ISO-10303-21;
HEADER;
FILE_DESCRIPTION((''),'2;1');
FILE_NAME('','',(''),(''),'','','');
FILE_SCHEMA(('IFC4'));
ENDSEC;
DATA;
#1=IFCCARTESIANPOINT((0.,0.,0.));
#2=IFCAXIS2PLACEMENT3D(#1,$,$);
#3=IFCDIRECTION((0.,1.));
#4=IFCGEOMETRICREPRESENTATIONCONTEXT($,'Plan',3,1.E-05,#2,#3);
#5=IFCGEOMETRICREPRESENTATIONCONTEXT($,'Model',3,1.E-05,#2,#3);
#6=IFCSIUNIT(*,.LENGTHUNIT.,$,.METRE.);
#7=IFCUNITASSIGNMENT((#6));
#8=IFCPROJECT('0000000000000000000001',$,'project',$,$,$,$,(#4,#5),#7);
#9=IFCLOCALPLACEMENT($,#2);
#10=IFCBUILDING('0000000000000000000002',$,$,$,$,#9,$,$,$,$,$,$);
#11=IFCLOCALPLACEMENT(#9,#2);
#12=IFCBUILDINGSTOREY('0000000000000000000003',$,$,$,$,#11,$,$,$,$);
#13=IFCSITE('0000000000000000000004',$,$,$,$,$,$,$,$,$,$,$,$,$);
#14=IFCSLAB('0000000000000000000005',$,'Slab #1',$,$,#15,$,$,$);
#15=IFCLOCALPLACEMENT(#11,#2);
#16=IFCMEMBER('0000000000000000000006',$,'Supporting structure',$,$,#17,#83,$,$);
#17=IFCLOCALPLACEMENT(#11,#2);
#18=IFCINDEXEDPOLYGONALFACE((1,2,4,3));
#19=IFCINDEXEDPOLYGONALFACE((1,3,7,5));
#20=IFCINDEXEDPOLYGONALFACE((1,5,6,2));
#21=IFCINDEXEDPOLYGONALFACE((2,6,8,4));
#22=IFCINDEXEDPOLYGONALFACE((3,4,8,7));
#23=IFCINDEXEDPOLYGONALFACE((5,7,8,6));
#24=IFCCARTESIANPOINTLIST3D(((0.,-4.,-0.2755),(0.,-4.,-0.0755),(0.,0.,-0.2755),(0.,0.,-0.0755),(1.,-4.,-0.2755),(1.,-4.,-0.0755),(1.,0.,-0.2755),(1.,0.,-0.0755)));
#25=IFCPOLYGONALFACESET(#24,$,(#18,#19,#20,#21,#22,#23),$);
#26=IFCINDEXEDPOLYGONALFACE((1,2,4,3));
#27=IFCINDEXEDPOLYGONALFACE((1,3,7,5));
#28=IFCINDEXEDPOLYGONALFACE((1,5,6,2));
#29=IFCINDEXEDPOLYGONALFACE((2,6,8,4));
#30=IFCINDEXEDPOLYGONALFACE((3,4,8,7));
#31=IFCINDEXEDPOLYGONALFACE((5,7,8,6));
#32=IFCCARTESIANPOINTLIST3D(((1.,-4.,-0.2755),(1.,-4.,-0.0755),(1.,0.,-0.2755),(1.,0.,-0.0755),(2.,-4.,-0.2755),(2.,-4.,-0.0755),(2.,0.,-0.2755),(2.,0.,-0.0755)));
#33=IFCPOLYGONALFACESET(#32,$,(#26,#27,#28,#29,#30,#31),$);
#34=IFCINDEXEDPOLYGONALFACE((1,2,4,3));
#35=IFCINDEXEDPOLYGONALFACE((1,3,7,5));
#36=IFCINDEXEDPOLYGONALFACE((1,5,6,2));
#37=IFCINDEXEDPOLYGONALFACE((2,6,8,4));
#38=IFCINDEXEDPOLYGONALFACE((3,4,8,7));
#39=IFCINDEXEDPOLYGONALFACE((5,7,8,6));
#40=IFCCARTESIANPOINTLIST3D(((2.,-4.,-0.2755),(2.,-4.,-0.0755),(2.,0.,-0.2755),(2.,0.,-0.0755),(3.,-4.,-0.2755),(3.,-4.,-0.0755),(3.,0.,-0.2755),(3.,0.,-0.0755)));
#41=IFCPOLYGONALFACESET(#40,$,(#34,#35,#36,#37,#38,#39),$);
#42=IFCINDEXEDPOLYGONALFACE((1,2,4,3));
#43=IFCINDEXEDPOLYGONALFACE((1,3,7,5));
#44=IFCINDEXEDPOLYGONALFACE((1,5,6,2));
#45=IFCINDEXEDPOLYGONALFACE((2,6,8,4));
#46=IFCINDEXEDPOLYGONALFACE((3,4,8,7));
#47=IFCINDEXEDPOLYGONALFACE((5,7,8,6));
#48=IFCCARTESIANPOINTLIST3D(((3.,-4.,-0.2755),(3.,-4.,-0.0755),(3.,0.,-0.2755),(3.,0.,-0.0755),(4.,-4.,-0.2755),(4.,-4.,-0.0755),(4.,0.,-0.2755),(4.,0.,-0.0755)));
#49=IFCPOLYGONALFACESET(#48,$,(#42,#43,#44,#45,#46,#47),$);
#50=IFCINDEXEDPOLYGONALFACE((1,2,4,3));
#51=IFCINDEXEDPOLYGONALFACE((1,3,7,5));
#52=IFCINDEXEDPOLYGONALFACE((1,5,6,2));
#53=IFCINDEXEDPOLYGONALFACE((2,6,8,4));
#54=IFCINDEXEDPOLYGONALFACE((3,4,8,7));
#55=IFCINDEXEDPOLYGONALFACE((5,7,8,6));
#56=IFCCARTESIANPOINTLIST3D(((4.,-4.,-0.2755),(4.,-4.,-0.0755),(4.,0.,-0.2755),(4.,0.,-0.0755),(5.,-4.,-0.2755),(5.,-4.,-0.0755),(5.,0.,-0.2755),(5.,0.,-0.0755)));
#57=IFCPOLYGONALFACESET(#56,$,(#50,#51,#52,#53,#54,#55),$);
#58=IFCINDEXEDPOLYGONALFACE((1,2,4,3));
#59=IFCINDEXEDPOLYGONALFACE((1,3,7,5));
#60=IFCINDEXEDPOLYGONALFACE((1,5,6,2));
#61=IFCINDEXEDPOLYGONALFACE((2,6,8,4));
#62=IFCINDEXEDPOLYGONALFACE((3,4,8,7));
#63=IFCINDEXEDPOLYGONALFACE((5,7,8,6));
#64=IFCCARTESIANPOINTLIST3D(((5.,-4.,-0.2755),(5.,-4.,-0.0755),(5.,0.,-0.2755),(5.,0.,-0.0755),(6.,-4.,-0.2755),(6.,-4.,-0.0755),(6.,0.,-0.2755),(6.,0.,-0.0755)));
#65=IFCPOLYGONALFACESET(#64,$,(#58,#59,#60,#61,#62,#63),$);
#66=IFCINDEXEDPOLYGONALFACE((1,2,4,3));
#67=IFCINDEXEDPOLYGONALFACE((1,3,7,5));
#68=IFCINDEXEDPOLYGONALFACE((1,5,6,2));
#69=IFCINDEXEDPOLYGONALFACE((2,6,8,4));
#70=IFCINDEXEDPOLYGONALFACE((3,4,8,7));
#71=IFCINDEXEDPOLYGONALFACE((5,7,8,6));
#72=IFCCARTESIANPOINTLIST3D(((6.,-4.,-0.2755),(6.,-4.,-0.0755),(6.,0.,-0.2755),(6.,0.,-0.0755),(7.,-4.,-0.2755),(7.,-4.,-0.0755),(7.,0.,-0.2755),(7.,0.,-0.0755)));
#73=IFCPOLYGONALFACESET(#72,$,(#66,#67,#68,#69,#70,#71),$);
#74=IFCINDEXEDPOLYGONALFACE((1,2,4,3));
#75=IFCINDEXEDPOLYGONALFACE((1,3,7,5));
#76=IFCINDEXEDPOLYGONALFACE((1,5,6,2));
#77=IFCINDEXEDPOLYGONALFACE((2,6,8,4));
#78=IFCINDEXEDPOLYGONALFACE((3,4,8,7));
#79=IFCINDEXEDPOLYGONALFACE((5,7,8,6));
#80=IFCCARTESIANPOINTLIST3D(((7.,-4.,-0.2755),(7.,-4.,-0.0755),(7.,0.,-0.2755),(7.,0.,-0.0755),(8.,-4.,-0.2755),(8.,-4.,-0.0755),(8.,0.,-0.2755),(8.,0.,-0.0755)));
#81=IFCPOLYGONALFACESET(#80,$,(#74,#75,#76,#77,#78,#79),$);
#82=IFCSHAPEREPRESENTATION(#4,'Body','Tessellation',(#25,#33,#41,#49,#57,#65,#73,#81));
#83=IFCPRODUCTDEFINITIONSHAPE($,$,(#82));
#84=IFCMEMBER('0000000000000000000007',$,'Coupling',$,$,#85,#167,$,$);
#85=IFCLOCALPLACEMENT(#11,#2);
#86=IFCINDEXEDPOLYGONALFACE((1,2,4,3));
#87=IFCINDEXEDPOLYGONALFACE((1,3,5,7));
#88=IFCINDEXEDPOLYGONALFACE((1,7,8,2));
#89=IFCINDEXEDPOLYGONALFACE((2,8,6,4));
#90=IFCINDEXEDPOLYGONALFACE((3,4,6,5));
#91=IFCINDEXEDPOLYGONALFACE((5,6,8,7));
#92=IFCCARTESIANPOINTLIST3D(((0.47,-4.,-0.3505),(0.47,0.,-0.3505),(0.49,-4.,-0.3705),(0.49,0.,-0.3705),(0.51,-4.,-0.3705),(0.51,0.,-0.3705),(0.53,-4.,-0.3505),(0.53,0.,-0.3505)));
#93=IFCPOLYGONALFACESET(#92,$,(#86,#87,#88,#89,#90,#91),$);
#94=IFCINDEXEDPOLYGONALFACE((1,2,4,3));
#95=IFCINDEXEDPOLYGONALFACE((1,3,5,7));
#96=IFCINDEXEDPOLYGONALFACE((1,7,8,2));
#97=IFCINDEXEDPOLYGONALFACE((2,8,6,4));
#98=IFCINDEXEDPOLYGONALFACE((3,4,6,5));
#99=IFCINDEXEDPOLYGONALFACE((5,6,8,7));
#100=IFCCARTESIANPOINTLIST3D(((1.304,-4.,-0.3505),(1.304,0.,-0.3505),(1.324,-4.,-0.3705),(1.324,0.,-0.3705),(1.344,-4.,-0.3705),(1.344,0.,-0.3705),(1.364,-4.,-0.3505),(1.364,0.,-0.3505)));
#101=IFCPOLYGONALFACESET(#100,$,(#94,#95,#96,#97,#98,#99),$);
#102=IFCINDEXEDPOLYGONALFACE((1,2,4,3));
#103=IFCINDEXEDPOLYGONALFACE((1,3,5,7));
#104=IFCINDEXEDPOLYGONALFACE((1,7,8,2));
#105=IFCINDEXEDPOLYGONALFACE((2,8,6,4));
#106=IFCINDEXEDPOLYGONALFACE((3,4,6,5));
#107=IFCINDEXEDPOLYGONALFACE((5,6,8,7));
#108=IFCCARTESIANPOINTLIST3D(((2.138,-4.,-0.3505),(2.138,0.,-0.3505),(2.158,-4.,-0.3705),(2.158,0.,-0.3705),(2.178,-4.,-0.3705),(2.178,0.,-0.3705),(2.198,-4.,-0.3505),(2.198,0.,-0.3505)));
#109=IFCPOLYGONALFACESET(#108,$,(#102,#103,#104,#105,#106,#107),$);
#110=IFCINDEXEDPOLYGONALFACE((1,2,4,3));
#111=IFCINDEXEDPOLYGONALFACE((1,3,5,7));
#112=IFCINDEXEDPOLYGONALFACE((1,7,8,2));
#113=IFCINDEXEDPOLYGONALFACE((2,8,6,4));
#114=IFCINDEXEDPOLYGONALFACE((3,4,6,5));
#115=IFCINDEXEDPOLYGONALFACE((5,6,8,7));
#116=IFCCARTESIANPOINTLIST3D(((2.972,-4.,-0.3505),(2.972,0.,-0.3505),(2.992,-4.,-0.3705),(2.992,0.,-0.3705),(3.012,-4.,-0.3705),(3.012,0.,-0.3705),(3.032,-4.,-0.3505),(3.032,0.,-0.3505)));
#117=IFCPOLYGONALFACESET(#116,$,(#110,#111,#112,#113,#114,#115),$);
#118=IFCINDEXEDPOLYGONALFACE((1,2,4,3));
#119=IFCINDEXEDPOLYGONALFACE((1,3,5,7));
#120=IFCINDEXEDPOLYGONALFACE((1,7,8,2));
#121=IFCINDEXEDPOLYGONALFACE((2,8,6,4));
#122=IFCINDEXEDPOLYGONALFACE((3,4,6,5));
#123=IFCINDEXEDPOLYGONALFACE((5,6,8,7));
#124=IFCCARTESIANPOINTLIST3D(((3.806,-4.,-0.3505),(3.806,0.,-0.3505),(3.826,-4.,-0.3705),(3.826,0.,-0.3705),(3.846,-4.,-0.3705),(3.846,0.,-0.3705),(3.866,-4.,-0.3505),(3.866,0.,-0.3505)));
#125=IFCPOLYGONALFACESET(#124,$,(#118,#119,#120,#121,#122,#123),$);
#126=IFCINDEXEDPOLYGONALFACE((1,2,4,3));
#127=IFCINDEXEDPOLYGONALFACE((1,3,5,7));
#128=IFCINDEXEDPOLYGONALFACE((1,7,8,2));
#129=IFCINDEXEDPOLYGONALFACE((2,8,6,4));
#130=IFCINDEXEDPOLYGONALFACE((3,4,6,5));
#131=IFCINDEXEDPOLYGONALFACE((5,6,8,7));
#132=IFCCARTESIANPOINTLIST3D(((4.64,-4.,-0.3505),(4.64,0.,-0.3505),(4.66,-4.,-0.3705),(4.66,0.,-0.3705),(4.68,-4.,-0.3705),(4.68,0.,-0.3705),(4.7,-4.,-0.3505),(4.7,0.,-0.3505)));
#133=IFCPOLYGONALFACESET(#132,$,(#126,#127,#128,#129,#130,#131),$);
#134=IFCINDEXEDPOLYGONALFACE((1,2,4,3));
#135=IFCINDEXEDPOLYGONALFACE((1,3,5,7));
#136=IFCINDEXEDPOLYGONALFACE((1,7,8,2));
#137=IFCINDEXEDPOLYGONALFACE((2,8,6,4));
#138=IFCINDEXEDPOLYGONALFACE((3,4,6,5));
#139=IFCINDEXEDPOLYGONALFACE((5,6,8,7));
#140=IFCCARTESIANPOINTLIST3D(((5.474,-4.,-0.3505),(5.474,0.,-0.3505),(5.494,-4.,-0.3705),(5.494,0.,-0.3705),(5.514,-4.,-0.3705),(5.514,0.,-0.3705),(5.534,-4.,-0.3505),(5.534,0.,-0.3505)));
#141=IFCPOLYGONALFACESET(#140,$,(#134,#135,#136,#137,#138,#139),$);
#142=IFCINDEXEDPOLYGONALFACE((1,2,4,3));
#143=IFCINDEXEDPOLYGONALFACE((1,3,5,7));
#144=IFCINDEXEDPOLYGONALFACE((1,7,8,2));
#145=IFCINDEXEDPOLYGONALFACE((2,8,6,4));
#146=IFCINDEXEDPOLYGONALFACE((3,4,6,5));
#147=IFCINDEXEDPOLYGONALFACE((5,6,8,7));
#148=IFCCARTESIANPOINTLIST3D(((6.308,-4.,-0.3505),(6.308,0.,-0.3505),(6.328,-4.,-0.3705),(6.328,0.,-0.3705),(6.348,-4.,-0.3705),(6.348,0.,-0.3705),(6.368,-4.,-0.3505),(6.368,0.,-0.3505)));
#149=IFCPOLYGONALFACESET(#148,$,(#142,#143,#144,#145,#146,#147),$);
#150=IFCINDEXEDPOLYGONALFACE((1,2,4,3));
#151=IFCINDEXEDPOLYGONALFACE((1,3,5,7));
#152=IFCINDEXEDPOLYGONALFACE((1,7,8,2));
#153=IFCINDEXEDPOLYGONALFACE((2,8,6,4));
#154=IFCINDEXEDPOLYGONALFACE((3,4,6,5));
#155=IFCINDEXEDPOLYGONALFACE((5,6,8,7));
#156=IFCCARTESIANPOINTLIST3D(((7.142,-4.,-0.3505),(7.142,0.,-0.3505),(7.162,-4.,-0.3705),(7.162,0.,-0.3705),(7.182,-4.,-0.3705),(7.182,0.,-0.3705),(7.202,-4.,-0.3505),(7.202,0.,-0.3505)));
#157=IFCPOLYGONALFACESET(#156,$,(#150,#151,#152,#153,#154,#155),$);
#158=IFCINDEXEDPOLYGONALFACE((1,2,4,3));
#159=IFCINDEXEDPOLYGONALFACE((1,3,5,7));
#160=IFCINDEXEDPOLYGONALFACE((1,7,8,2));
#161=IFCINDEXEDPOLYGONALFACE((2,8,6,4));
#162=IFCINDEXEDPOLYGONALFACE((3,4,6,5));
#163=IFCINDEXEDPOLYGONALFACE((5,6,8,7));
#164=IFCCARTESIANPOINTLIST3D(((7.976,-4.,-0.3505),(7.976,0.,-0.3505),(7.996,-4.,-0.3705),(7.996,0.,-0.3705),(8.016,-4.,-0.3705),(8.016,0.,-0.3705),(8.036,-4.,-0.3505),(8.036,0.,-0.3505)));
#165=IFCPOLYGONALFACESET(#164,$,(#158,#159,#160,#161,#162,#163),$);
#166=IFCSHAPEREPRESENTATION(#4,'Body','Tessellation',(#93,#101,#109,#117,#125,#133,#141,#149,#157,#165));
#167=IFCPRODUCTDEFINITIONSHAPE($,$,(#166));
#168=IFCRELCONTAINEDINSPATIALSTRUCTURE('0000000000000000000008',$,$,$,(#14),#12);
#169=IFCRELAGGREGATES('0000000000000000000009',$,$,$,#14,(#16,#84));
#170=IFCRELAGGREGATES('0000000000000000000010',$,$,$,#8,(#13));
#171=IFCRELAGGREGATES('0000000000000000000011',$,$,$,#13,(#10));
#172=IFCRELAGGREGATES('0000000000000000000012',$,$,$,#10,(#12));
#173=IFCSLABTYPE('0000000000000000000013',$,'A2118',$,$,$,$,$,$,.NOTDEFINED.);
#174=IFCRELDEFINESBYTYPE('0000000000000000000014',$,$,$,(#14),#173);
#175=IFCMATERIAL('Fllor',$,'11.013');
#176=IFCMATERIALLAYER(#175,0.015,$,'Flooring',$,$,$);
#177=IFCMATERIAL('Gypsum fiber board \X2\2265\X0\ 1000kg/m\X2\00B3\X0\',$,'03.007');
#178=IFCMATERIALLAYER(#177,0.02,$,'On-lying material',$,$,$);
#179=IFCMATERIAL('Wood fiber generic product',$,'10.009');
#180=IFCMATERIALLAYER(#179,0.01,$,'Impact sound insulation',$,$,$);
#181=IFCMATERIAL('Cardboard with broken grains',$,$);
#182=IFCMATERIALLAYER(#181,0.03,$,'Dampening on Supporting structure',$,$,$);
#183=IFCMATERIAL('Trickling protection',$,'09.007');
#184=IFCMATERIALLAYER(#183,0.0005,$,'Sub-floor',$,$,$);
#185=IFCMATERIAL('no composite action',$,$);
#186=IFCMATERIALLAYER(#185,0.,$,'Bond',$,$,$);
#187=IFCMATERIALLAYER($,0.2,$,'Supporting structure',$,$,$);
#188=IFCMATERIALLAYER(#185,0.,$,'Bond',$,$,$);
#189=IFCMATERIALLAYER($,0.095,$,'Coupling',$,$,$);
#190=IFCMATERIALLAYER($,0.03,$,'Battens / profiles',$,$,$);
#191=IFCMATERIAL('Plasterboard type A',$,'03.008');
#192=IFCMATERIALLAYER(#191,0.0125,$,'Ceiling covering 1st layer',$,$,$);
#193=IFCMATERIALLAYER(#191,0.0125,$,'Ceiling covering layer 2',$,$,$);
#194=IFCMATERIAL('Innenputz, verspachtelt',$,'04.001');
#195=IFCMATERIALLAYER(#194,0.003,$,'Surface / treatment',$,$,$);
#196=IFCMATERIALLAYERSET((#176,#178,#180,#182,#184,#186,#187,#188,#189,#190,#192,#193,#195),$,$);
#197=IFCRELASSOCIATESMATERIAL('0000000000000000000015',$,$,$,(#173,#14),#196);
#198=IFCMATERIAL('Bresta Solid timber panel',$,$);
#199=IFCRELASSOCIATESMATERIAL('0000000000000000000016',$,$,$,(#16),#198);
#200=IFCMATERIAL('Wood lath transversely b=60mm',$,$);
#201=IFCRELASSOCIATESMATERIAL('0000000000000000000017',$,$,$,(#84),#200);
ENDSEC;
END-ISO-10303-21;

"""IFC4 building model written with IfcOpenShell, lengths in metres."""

from ifc_helpers import new_model, si_unit, direction, frame, frame_2d, origin, place, context, project, spatial, polyline, rectangle, outline, extrude, material, layer, layer_set, type_object, element, aggregate, save


model = new_model("IFC4")

# Units and contexts
plan_context = context("Plan", 3, precision=1e-05, world=origin(), true_north=direction((0.0, 1.0)))
model_context = context("Model", 3, precision=1e-05, world=origin(), true_north=direction((0.0, 1.0)))
ifc_project = project(units=[si_unit("LENGTHUNIT", "METRE")], contexts=[plan_context, model_context])

# Site, building, storey
site = spatial("IfcSite", under=ifc_project)
building_placement = place(None, origin())
building = spatial("IfcBuilding", under=site, at=building_placement)
storey_placement = place(building_placement, origin())
storey = spatial("IfcBuildingStorey", under=building, at=storey_placement)

# Slab, members
ifc_material_1 = material(Name="Fllor", Category="11.013")
ifc_layer_1 = layer(ifc_material_1, 0.015, Name="Flooring")
ifc_material_2 = material(Name="Gypsum fiber board ≥ 1000kg/m³", Category="03.007")
ifc_layer_2 = layer(ifc_material_2, 0.02, Name="On-lying material")
ifc_material_3 = material(Name="Wood fiber generic product", Category="10.009")
ifc_layer_3 = layer(ifc_material_3, 0.01, Name="Impact sound insulation")
ifc_material_4 = material(Name="Cardboard with broken grains")
ifc_layer_4 = layer(ifc_material_4, 0.03, Name="Dampening on Supporting structure")
ifc_material_5 = material(Name="Trickling protection", Category="09.007")
ifc_layer_5 = layer(ifc_material_5, 0.0005, Name="Sub-floor")
ifc_material_6 = material(Name="no composite action")
ifc_layer_6 = layer(ifc_material_6, 0.0, Name="Bond")
ifc_layer_7 = layer(None, 0.2, Name="Supporting structure")
ifc_layer_8 = layer(ifc_material_6, 0.0, Name="Bond")
ifc_layer_9 = layer(None, 0.095, Name="Coupling")
ifc_layer_10 = layer(None, 0.03, Name="Battens / profiles")
ifc_material_7 = material(Name="Plasterboard type A", Category="03.008")
ifc_layer_11 = layer(ifc_material_7, 0.0125, Name="Ceiling covering 1st layer")
ifc_layer_12 = layer(ifc_material_7, 0.0125, Name="Ceiling covering layer 2")
ifc_material_8 = material(Name="Innenputz, verspachtelt", Category="04.001")
ifc_layer_13 = layer(ifc_material_8, 0.003, Name="Surface / treatment")
ifc_layer_set = layer_set([ifc_layer_1, ifc_layer_2, ifc_layer_3, ifc_layer_4, ifc_layer_5, ifc_layer_6, ifc_layer_7, ifc_layer_8, ifc_layer_9, ifc_layer_10, ifc_layer_11, ifc_layer_12, ifc_layer_13])
slab_type = type_object("IfcSlabType", Name="A2118", PredefinedType="NOTDEFINED", material=ifc_layer_set)
slab_placement = place(None, frame((0.0, 0.0, 0.0), z_axis=(0.0, 0.0, -1.0), x_axis=(1.0, 0.0, 0.0)))
slab = element("IfcSlab", 1, at=slab_placement, inside=storey, type_object=slab_type, material=ifc_layer_set, Name="Slab #1")
ifc_material_9 = material(Name="Bresta Solid timber panel")
member_1_placement = place(slab_placement, origin())
member_1 = element("IfcMember", 2, at=member_1_placement, material=ifc_material_9, Name="Supporting structure", context=plan_context, shape_type="SweptSolid", body=[
    extrude(rectangle(XDim=1.0, YDim=0.2, at=frame_2d((0.5, 0.1), x_axis=(1.0, 0.0))), frame((0.0, 4.0, 0.0755), z_axis=(0.0, -1.0, 0.0), x_axis=(1.0, 0.0, 0.0)), (0.0, 0.0, 1.0), 4.0),
    extrude(rectangle(XDim=1.0, YDim=0.2, at=frame_2d((0.5, 0.1), x_axis=(1.0, 0.0))), frame((1.0, 4.0, 0.0755), z_axis=(0.0, -1.0, 0.0), x_axis=(1.0, 0.0, 0.0)), (0.0, 0.0, 1.0), 4.0),
    extrude(rectangle(XDim=1.0, YDim=0.2, at=frame_2d((0.5, 0.1), x_axis=(1.0, 0.0))), frame((2.0, 4.0, 0.0755), z_axis=(0.0, -1.0, 0.0), x_axis=(1.0, 0.0, 0.0)), (0.0, 0.0, 1.0), 4.0),
    extrude(rectangle(XDim=1.0, YDim=0.2, at=frame_2d((0.5, 0.1), x_axis=(1.0, 0.0))), frame((3.0, 4.0, 0.0755), z_axis=(0.0, -1.0, 0.0), x_axis=(1.0, 0.0, 0.0)), (0.0, 0.0, 1.0), 4.0),
    extrude(rectangle(XDim=1.0, YDim=0.2, at=frame_2d((0.5, 0.1), x_axis=(1.0, 0.0))), frame((4.0, 4.0, 0.0755), z_axis=(0.0, -1.0, 0.0), x_axis=(1.0, 0.0, 0.0)), (0.0, 0.0, 1.0), 4.0),
    extrude(rectangle(XDim=1.0, YDim=0.2, at=frame_2d((0.5, 0.1), x_axis=(1.0, 0.0))), frame((5.0, 4.0, 0.0755), z_axis=(0.0, -1.0, 0.0), x_axis=(1.0, 0.0, 0.0)), (0.0, 0.0, 1.0), 4.0),
    extrude(rectangle(XDim=1.0, YDim=0.2, at=frame_2d((0.5, 0.1), x_axis=(1.0, 0.0))), frame((6.0, 4.0, 0.0755), z_axis=(0.0, -1.0, 0.0), x_axis=(1.0, 0.0, 0.0)), (0.0, 0.0, 1.0), 4.0),
    extrude(rectangle(XDim=1.0, YDim=0.2, at=frame_2d((0.5, 0.1), x_axis=(1.0, 0.0))), frame((7.0, 4.0, 0.0755), z_axis=(0.0, -1.0, 0.0), x_axis=(1.0, 0.0, 0.0)), (0.0, 0.0, 1.0), 4.0),
])
ifc_material_10 = material(Name="Wood lath transversely b=60mm")
member_2_placement = place(slab_placement, origin())
member_2 = element("IfcMember", 3, at=member_2_placement, material=ifc_material_10, Name="Coupling", context=plan_context, shape_type="SweptSolid", body=[
    extrude(outline(polyline([(0.0, 0.0), (0.06, 0.0), (0.04, 0.02), (0.02, 0.02), (0.0, 0.0)])), frame((0.47, 4.0, 0.3505), z_axis=(0.0, -1.0, 0.0), x_axis=(1.0, 0.0, 0.0)), (0.0, 0.0, 1.0), 4.0),
    extrude(outline(polyline([(0.0, 0.0), (0.06, 0.0), (0.04, 0.02), (0.02, 0.02), (0.0, 0.0)])), frame((1.304, 4.0, 0.3505), z_axis=(0.0, -1.0, 0.0), x_axis=(1.0, 0.0, 0.0)), (0.0, 0.0, 1.0), 4.0),
    extrude(outline(polyline([(0.0, 0.0), (0.06, 0.0), (0.04, 0.02), (0.02, 0.02), (0.0, 0.0)])), frame((2.138, 4.0, 0.3505), z_axis=(0.0, -1.0, 0.0), x_axis=(1.0, 0.0, 0.0)), (0.0, 0.0, 1.0), 4.0),
    extrude(outline(polyline([(0.0, 0.0), (0.06, 0.0), (0.04, 0.02), (0.02, 0.02), (0.0, 0.0)])), frame((2.972, 4.0, 0.3505), z_axis=(0.0, -1.0, 0.0), x_axis=(1.0, 0.0, 0.0)), (0.0, 0.0, 1.0), 4.0),
    extrude(outline(polyline([(0.0, 0.0), (0.06, 0.0), (0.04, 0.02), (0.02, 0.02), (0.0, 0.0)])), frame((3.806, 4.0, 0.3505), z_axis=(0.0, -1.0, 0.0), x_axis=(1.0, 0.0, 0.0)), (0.0, 0.0, 1.0), 4.0),
    extrude(outline(polyline([(0.0, 0.0), (0.06, 0.0), (0.04, 0.02), (0.02, 0.02), (0.0, 0.0)])), frame((4.64, 4.0, 0.3505), z_axis=(0.0, -1.0, 0.0), x_axis=(1.0, 0.0, 0.0)), (0.0, 0.0, 1.0), 4.0),
    extrude(outline(polyline([(0.0, 0.0), (0.06, 0.0), (0.04, 0.02), (0.02, 0.02), (0.0, 0.0)])), frame((5.474, 4.0, 0.3505), z_axis=(0.0, -1.0, 0.0), x_axis=(1.0, 0.0, 0.0)), (0.0, 0.0, 1.0), 4.0),
    extrude(outline(polyline([(0.0, 0.0), (0.06, 0.0), (0.04, 0.02), (0.02, 0.02), (0.0, 0.0)])), frame((6.308, 4.0, 0.3505), z_axis=(0.0, -1.0, 0.0), x_axis=(1.0, 0.0, 0.0)), (0.0, 0.0, 1.0), 4.0),
    extrude(outline(polyline([(0.0, 0.0), (0.06, 0.0), (0.04, 0.02), (0.02, 0.02), (0.0, 0.0)])), frame((7.142, 4.0, 0.3505), z_axis=(0.0, -1.0, 0.0), x_axis=(1.0, 0.0, 0.0)), (0.0, 0.0, 1.0), 4.0),
    extrude(outline(polyline([(0.0, 0.0), (0.06, 0.0), (0.04, 0.02), (0.02, 0.02), (0.0, 0.0)])), frame((7.976, 4.0, 0.3505), z_axis=(0.0, -1.0, 0.0), x_axis=(1.0, 0.0, 0.0)), (0.0, 0.0, 1.0), 4.0),
])
aggregate(slab, [member_1, member_2])

save(model, "model.ifc")
